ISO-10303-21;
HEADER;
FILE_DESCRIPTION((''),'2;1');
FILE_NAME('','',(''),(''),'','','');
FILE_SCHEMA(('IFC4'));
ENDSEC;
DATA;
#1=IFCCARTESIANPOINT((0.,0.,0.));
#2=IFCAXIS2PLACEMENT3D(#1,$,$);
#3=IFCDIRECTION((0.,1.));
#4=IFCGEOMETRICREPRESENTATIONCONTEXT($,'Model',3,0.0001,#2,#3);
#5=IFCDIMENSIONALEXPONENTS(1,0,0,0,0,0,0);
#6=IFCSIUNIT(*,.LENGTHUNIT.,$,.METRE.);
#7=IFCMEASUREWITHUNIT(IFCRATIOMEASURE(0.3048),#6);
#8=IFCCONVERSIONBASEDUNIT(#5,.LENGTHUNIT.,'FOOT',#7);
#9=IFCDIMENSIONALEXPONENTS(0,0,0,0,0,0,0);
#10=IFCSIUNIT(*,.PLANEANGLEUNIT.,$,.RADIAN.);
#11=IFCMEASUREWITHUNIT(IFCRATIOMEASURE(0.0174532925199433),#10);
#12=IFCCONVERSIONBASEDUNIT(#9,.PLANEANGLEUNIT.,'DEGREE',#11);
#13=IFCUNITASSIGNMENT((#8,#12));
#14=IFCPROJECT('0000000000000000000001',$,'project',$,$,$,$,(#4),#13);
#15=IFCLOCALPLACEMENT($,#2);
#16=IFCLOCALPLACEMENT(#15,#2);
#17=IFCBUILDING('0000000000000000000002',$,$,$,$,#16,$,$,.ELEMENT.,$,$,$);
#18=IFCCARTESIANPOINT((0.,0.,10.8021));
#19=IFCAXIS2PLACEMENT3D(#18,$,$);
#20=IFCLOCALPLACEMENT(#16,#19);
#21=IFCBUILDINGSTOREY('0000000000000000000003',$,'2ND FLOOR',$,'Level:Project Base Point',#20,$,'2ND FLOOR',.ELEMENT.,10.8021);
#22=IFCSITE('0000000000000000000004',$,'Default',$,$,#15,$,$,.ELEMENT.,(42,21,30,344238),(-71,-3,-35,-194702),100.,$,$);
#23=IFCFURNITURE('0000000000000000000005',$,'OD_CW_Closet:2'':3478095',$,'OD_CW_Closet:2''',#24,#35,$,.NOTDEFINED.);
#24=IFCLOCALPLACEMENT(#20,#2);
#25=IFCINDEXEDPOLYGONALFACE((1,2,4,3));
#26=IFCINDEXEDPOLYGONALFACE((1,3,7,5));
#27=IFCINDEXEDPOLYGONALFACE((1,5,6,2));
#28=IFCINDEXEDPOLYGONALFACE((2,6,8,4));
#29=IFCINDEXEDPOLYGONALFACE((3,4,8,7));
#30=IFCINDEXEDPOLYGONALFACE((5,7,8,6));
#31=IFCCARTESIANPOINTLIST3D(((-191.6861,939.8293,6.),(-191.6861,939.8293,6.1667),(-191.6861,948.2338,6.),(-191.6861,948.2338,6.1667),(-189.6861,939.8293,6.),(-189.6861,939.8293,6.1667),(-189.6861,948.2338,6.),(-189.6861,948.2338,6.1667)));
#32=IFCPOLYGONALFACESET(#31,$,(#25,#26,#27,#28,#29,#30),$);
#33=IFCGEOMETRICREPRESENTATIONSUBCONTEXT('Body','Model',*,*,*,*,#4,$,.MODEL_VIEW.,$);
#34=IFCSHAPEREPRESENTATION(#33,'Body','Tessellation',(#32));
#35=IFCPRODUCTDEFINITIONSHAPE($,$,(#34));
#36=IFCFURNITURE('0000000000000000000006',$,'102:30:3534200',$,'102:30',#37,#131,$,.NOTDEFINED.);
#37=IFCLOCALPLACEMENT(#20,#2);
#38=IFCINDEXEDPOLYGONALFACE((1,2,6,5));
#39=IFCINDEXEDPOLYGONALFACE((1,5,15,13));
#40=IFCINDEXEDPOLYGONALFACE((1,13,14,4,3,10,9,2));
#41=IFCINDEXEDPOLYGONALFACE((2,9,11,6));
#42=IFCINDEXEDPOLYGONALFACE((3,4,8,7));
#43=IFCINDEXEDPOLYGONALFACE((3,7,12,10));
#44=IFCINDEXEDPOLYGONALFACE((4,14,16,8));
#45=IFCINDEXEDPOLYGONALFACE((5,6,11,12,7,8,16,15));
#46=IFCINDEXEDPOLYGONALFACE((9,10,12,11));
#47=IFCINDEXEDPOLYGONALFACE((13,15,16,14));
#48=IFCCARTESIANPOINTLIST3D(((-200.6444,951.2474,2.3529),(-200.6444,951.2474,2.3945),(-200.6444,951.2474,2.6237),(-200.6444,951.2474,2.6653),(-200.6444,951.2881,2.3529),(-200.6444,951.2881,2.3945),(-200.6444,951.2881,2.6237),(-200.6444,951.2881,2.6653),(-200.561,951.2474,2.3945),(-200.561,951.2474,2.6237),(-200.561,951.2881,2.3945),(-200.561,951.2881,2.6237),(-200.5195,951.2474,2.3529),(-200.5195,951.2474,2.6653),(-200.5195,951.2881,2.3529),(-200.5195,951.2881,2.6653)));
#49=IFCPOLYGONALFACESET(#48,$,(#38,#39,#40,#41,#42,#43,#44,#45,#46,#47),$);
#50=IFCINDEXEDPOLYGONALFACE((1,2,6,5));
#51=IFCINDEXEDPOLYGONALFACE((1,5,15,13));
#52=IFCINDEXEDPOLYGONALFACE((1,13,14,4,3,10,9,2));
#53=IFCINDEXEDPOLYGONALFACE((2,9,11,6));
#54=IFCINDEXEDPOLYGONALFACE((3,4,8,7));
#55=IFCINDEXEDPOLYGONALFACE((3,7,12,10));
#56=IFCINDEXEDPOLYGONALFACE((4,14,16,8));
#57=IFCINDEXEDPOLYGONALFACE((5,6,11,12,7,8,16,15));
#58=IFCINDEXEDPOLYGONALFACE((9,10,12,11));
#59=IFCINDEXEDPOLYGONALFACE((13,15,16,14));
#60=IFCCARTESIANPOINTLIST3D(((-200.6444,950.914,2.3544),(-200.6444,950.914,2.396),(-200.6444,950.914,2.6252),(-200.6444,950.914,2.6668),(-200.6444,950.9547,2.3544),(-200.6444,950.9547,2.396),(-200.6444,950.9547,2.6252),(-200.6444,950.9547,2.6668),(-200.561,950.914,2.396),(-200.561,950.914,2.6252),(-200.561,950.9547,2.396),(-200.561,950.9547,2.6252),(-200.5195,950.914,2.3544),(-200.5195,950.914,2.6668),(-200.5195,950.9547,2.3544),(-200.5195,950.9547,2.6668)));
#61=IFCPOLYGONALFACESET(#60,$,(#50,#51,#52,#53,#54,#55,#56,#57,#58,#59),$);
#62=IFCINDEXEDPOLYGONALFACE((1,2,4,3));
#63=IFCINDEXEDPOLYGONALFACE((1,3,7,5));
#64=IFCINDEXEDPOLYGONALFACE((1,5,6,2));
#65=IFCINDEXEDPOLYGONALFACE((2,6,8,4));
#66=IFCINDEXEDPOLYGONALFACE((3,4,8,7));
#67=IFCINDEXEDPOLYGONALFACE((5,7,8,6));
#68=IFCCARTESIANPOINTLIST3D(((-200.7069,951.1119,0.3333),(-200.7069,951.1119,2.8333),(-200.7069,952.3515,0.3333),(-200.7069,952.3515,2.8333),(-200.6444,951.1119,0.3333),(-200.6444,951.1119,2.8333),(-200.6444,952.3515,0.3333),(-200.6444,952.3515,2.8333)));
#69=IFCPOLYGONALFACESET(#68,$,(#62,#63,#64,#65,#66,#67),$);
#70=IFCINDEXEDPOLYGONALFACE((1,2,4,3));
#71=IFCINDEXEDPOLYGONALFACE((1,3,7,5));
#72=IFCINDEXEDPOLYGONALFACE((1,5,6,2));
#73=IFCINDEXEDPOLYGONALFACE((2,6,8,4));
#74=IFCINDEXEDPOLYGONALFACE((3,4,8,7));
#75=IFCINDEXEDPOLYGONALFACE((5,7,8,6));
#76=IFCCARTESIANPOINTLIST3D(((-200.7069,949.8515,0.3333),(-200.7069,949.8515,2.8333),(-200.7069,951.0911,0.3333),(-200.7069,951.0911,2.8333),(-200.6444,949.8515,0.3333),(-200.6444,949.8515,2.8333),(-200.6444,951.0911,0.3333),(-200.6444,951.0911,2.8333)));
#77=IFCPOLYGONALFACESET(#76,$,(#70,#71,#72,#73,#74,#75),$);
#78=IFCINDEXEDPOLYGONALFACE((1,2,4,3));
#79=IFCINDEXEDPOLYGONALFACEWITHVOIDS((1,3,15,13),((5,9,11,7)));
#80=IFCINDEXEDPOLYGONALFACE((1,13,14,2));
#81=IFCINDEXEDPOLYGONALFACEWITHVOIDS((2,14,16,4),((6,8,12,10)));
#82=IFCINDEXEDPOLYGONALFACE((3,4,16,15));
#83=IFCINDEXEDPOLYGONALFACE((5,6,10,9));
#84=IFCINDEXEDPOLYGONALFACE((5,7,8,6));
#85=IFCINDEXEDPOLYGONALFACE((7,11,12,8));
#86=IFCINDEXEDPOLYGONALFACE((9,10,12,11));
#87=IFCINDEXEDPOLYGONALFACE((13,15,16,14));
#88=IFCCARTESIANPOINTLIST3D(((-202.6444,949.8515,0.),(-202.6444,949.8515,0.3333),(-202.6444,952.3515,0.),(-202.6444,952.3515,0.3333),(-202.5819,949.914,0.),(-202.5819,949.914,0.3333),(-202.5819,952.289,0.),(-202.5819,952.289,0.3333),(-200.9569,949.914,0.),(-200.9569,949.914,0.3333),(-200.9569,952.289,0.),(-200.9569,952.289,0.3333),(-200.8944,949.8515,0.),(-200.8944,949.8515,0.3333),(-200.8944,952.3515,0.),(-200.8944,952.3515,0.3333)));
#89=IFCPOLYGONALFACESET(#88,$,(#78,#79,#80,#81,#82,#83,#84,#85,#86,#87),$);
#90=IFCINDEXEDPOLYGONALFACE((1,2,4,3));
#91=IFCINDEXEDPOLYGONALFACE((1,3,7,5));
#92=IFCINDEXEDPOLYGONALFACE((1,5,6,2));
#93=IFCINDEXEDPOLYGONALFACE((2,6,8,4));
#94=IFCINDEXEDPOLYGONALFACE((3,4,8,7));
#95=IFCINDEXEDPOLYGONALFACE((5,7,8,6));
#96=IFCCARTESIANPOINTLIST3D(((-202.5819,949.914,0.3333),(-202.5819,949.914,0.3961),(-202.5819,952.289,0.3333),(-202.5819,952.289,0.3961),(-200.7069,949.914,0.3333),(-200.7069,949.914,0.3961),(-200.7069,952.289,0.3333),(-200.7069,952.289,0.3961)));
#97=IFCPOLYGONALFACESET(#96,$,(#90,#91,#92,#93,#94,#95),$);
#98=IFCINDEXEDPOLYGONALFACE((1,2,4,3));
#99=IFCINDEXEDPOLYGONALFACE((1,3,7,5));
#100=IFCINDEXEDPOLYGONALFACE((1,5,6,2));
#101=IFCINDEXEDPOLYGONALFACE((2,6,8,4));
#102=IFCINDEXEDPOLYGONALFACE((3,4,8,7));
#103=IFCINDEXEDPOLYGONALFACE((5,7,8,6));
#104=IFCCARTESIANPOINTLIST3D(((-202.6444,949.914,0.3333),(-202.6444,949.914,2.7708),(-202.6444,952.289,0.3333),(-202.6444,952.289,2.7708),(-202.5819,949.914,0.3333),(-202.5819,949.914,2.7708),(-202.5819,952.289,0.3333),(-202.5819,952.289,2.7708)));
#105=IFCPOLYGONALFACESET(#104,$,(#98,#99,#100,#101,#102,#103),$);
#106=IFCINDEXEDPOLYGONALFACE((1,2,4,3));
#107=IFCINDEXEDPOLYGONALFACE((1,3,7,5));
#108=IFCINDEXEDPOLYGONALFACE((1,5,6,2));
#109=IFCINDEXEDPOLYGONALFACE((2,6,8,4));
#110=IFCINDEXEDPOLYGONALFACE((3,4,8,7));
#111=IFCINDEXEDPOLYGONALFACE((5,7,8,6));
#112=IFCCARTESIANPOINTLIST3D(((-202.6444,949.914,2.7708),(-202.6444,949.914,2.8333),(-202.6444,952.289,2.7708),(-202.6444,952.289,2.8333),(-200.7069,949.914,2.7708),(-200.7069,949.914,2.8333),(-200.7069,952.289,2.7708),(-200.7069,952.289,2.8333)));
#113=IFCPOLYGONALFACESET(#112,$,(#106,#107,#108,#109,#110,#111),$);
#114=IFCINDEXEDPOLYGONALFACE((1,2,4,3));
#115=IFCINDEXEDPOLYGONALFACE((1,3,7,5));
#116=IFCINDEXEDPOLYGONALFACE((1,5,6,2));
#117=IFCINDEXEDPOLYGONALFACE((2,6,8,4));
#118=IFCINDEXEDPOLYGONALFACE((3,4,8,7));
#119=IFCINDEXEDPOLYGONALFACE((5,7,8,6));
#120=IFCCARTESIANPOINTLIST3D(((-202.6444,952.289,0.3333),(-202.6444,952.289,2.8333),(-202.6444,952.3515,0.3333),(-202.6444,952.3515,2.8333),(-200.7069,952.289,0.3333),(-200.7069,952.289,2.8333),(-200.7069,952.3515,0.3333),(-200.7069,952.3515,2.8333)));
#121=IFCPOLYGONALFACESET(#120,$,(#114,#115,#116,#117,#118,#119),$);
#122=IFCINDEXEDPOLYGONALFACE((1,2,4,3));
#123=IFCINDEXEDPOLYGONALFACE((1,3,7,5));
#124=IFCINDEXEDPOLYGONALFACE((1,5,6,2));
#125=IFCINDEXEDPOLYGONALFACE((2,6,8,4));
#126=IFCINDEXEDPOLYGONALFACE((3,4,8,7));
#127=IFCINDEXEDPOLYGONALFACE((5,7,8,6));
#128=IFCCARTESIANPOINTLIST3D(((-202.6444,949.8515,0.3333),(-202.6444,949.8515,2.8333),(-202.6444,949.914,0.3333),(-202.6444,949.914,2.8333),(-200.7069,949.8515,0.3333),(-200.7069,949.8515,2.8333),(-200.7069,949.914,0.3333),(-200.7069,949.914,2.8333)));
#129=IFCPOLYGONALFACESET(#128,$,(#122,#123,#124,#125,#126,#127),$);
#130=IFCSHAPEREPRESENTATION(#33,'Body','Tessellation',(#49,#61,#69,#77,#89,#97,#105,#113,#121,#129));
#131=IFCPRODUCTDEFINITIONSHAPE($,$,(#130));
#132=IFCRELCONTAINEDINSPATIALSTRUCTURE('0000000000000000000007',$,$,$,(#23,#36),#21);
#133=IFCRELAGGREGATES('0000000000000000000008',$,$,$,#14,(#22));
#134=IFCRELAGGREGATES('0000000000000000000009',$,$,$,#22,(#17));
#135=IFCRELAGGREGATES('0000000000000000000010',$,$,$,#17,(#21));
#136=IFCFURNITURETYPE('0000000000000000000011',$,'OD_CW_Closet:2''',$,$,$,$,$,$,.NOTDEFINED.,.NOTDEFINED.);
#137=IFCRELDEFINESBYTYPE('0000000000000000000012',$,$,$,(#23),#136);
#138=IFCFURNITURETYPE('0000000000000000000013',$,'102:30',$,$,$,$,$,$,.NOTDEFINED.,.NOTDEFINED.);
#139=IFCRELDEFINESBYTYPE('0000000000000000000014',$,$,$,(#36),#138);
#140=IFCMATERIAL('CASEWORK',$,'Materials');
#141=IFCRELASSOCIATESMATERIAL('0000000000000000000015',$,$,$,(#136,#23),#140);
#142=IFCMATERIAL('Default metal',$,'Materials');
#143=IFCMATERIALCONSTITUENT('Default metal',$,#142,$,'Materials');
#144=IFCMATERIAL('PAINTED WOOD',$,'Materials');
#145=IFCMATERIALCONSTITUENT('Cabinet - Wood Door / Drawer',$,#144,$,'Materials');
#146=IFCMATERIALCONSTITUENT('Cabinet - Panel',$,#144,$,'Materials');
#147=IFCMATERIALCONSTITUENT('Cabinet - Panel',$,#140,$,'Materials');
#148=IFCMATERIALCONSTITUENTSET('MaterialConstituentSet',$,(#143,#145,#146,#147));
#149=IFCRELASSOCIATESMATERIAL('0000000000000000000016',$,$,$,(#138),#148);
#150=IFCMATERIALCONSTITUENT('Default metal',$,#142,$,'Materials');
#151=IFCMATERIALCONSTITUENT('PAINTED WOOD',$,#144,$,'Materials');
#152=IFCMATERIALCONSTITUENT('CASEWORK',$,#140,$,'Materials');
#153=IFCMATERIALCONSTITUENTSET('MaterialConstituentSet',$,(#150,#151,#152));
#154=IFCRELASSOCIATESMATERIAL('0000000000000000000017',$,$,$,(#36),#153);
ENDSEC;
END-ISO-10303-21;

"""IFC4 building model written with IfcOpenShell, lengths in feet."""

from ifc_helpers import new_model, entity, si_unit, converted_unit, direction, frame, frame_2d, origin, origin_2d_with_axis, place, context, subcontext, project, spatial, polyline, rectangle, outline, extrude, source, transform, mapped, material, constituent, constituent_set, type_object, type_shapes, element, save


model = new_model("IFC4")

# Units and contexts
model_context = context("Model", 3, precision=0.0001, world=origin(), true_north=direction((0.0, 1.0)))
body_context = subcontext(model_context, "Body", "Model", "MODEL_VIEW")
ifc_project = project(units=[converted_unit("LENGTHUNIT", "FOOT", entity("IfcRatioMeasure", 0.3048), si_unit("LENGTHUNIT", "METRE"), dimensions=[1, 0, 0, 0, 0, 0, 0]), converted_unit("PLANEANGLEUNIT", "DEGREE", entity("IfcRatioMeasure", 0.0174532925199433), si_unit("PLANEANGLEUNIT", "RADIAN"), dimensions=[0, 0, 0, 0, 0, 0, 0])], contexts=[model_context])

# Site, building, storey
site_placement = place(None, origin())
site = spatial("IfcSite", under=ifc_project, at=site_placement, Name="Default", CompositionType="ELEMENT", RefLatitude=(42, 21, 30, 344238), RefLongitude=(-71, -3, -35, -194702), RefElevation=100.0)
building_placement = place(site_placement, origin())
building = spatial("IfcBuilding", under=site, at=building_placement, CompositionType="ELEMENT")
storey_placement = place(building_placement, frame((0.0, 0.0, 10.8021)))
storey = spatial("IfcBuildingStorey", under=building, at=storey_placement, Name="2ND FLOOR", ObjectType="Level:Project Base Point", LongName="2ND FLOOR", CompositionType="ELEMENT", Elevation=10.8021)

# Furniture
ifc_material_1 = material(Name="CASEWORK", Category="Materials")
furniture_type_1 = type_object("IfcFurnitureType", Name="OD_CW_Closet:2'", AssemblyPlace="NOTDEFINED", PredefinedType="NOTDEFINED", material=ifc_material_1)
shared_shape_1 = source(origin(), body_context, "Body", "SweptSolid", [
    extrude(rectangle(XDim=8.4045, YDim=2.0, at=frame_2d((0.0, 0.0), x_axis=(1.0, 0.0))), frame((4.2022, 1.0, 0.0)), (0.0, 0.0, 1.0), 0.1667),
])
type_shapes(furniture_type_1, [shared_shape_1])
furniture_1_placement = place(storey_placement, frame((-191.6861, 948.2338, 6.0), z_axis=(0.0, 0.0, 1.0), x_axis=(0.0, -1.0, 0.0)))
element("IfcFurniture", 1, at=furniture_1_placement, inside=storey, type_object=furniture_type_1, material=ifc_material_1, Name="OD_CW_Closet:2':3478095", ObjectType="OD_CW_Closet:2'", PredefinedType="NOTDEFINED", context=body_context, shape_type="MappedRepresentation", body=[
    mapped(shared_shape_1, transform((0.0, 0.0, 0.0), scale=1.0)),
])
ifc_material_2 = material(Name="Default metal", Category="Materials")
ifc_constituent_1 = constituent(ifc_material_2, Name="Default metal", Category="Materials")
ifc_material_3 = material(Name="PAINTED WOOD", Category="Materials")
ifc_constituent_2 = constituent(ifc_material_3, Name="PAINTED WOOD", Category="Materials")
ifc_constituent_3 = constituent(ifc_material_1, Name="CASEWORK", Category="Materials")
ifc_constituent_set_1 = constituent_set(constituents=[ifc_constituent_1, ifc_constituent_2, ifc_constituent_3], Name="MaterialConstituentSet")
ifc_constituent_4 = constituent(ifc_material_2, Name="Default metal", Category="Materials")
ifc_constituent_5 = constituent(ifc_material_3, Name="Cabinet - Wood Door / Drawer", Category="Materials")
ifc_constituent_6 = constituent(ifc_material_3, Name="Cabinet - Panel", Category="Materials")
ifc_constituent_7 = constituent(ifc_material_1, Name="Cabinet - Panel", Category="Materials")
ifc_constituent_set_2 = constituent_set(constituents=[ifc_constituent_4, ifc_constituent_5, ifc_constituent_6, ifc_constituent_7], Name="MaterialConstituentSet")
furniture_type_2 = type_object("IfcFurnitureType", Name="102:30", AssemblyPlace="NOTDEFINED", PredefinedType="NOTDEFINED", material=ifc_constituent_set_2)
shared_shape_2 = source(origin(), body_context, "Body", "SweptSolid", [
    extrude(outline(polyline([(0.1146, -0.0521), (0.1562, -0.0521), (0.1562, 0.0729), (-0.1562, 0.0729), (-0.1562, -0.0521), (-0.1146, -0.0521), (-0.1146, 0.0313), (0.1146, 0.0313), (0.1146, -0.0521)])), frame((0.2073, -2.0521, 2.5091), z_axis=(1.0, 0.0, 0.0), x_axis=(0.0, 0.0, 1.0)), (0.0, 0.0, 1.0), 0.0407),
    extrude(outline(polyline([(0.1146, -0.0521), (0.1562, -0.0521), (0.1562, 0.0729), (-0.1562, 0.0729), (-0.1562, -0.0521), (-0.1146, -0.0521), (-0.1146, 0.0313), (0.1146, 0.0313), (0.1146, -0.0521)])), frame((-0.126, -2.0521, 2.5106), z_axis=(1.0, 0.0, 0.0), x_axis=(0.0, 0.0, 1.0)), (0.0, 0.0, 1.0), 0.0407),
    extrude(rectangle(XDim=0.0625, YDim=1.2396, at=frame_2d((0.0, 0.0), x_axis=(1.0, 0.0))), frame((0.6917, -1.9688, 0.3333), z_axis=(0.0, 0.0, 1.0), x_axis=(0.0, 1.0, 0.0)), (0.0, 0.0, 1.0), 2.5),
    extrude(rectangle(XDim=0.0625, YDim=1.2396, at=origin_2d_with_axis()), frame((-0.5687, -1.9688, 0.3333), z_axis=(0.0, 0.0, 1.0), x_axis=(0.0, 1.0, 0.0)), (0.0, 0.0, 1.0), 2.5),
    extrude(outline(polyline([(-1.25, -0.875), (1.25, -0.875), (1.25, 0.875), (-1.25, 0.875), (-1.25, -0.875)]), holes=[polyline([(-1.1875, -0.8125), (-1.1875, 0.8125), (1.1875, 0.8125), (1.1875, -0.8125), (-1.1875, -0.8125)])]), frame((0.0615, -0.875, 0.0)), (0.0, 0.0, 1.0), 0.3333),
    extrude(rectangle(XDim=2.375, YDim=1.875, at=frame_2d((0.0, 0.0), x_axis=(1.0, 0.0))), frame((0.0615, -1.0, 0.3333), z_axis=(0.0, 0.0, 1.0), x_axis=(-1.0, 0.0, 0.0)), (0.0, 0.0, 1.0), 0.0627),
    extrude(rectangle(XDim=0.0625, YDim=2.375, at=origin_2d_with_axis()), frame((0.0615, -0.0312, 0.3333), z_axis=(0.0, 0.0, 1.0), x_axis=(0.0, 1.0, 0.0)), (0.0, 0.0, 1.0), 2.4375),
    extrude(rectangle(XDim=2.375, YDim=1.9375, at=origin_2d_with_axis()), frame((0.0615, -0.9688, 2.7708), z_axis=(0.0, 0.0, 1.0), x_axis=(-1.0, 0.0, 0.0)), (0.0, 0.0, 1.0), 0.0625),
    extrude(rectangle(XDim=0.0625, YDim=1.9375, at=frame_2d((0.0, 0.0), x_axis=(1.0, 0.0))), frame((1.2802, -0.9687, 0.3333)), (0.0, 0.0, 1.0), 2.5),
    extrude(rectangle(XDim=0.0625, YDim=1.9375, at=frame_2d((0.0, 0.0), x_axis=(1.0, 0.0))), frame((-1.1573, -0.9687, 0.3333)), (0.0, 0.0, 1.0), 2.5),
])
type_shapes(furniture_type_2, [shared_shape_2])
furniture_2_placement = place(storey_placement, frame((-202.6444, 951.04, 0.0), z_axis=(0.0, 0.0, 1.0), x_axis=(0.0, 1.0, 0.0)))
element("IfcFurniture", 2, at=furniture_2_placement, inside=storey, type_object=furniture_type_2, material=ifc_constituent_set_1, Name="102:30:3534200", ObjectType="102:30", PredefinedType="NOTDEFINED", context=body_context, shape_type="MappedRepresentation", body=[
    mapped(shared_shape_2, transform((0.0, 0.0, 0.0), scale=1.0)),
])

save(model, "model.ifc")
